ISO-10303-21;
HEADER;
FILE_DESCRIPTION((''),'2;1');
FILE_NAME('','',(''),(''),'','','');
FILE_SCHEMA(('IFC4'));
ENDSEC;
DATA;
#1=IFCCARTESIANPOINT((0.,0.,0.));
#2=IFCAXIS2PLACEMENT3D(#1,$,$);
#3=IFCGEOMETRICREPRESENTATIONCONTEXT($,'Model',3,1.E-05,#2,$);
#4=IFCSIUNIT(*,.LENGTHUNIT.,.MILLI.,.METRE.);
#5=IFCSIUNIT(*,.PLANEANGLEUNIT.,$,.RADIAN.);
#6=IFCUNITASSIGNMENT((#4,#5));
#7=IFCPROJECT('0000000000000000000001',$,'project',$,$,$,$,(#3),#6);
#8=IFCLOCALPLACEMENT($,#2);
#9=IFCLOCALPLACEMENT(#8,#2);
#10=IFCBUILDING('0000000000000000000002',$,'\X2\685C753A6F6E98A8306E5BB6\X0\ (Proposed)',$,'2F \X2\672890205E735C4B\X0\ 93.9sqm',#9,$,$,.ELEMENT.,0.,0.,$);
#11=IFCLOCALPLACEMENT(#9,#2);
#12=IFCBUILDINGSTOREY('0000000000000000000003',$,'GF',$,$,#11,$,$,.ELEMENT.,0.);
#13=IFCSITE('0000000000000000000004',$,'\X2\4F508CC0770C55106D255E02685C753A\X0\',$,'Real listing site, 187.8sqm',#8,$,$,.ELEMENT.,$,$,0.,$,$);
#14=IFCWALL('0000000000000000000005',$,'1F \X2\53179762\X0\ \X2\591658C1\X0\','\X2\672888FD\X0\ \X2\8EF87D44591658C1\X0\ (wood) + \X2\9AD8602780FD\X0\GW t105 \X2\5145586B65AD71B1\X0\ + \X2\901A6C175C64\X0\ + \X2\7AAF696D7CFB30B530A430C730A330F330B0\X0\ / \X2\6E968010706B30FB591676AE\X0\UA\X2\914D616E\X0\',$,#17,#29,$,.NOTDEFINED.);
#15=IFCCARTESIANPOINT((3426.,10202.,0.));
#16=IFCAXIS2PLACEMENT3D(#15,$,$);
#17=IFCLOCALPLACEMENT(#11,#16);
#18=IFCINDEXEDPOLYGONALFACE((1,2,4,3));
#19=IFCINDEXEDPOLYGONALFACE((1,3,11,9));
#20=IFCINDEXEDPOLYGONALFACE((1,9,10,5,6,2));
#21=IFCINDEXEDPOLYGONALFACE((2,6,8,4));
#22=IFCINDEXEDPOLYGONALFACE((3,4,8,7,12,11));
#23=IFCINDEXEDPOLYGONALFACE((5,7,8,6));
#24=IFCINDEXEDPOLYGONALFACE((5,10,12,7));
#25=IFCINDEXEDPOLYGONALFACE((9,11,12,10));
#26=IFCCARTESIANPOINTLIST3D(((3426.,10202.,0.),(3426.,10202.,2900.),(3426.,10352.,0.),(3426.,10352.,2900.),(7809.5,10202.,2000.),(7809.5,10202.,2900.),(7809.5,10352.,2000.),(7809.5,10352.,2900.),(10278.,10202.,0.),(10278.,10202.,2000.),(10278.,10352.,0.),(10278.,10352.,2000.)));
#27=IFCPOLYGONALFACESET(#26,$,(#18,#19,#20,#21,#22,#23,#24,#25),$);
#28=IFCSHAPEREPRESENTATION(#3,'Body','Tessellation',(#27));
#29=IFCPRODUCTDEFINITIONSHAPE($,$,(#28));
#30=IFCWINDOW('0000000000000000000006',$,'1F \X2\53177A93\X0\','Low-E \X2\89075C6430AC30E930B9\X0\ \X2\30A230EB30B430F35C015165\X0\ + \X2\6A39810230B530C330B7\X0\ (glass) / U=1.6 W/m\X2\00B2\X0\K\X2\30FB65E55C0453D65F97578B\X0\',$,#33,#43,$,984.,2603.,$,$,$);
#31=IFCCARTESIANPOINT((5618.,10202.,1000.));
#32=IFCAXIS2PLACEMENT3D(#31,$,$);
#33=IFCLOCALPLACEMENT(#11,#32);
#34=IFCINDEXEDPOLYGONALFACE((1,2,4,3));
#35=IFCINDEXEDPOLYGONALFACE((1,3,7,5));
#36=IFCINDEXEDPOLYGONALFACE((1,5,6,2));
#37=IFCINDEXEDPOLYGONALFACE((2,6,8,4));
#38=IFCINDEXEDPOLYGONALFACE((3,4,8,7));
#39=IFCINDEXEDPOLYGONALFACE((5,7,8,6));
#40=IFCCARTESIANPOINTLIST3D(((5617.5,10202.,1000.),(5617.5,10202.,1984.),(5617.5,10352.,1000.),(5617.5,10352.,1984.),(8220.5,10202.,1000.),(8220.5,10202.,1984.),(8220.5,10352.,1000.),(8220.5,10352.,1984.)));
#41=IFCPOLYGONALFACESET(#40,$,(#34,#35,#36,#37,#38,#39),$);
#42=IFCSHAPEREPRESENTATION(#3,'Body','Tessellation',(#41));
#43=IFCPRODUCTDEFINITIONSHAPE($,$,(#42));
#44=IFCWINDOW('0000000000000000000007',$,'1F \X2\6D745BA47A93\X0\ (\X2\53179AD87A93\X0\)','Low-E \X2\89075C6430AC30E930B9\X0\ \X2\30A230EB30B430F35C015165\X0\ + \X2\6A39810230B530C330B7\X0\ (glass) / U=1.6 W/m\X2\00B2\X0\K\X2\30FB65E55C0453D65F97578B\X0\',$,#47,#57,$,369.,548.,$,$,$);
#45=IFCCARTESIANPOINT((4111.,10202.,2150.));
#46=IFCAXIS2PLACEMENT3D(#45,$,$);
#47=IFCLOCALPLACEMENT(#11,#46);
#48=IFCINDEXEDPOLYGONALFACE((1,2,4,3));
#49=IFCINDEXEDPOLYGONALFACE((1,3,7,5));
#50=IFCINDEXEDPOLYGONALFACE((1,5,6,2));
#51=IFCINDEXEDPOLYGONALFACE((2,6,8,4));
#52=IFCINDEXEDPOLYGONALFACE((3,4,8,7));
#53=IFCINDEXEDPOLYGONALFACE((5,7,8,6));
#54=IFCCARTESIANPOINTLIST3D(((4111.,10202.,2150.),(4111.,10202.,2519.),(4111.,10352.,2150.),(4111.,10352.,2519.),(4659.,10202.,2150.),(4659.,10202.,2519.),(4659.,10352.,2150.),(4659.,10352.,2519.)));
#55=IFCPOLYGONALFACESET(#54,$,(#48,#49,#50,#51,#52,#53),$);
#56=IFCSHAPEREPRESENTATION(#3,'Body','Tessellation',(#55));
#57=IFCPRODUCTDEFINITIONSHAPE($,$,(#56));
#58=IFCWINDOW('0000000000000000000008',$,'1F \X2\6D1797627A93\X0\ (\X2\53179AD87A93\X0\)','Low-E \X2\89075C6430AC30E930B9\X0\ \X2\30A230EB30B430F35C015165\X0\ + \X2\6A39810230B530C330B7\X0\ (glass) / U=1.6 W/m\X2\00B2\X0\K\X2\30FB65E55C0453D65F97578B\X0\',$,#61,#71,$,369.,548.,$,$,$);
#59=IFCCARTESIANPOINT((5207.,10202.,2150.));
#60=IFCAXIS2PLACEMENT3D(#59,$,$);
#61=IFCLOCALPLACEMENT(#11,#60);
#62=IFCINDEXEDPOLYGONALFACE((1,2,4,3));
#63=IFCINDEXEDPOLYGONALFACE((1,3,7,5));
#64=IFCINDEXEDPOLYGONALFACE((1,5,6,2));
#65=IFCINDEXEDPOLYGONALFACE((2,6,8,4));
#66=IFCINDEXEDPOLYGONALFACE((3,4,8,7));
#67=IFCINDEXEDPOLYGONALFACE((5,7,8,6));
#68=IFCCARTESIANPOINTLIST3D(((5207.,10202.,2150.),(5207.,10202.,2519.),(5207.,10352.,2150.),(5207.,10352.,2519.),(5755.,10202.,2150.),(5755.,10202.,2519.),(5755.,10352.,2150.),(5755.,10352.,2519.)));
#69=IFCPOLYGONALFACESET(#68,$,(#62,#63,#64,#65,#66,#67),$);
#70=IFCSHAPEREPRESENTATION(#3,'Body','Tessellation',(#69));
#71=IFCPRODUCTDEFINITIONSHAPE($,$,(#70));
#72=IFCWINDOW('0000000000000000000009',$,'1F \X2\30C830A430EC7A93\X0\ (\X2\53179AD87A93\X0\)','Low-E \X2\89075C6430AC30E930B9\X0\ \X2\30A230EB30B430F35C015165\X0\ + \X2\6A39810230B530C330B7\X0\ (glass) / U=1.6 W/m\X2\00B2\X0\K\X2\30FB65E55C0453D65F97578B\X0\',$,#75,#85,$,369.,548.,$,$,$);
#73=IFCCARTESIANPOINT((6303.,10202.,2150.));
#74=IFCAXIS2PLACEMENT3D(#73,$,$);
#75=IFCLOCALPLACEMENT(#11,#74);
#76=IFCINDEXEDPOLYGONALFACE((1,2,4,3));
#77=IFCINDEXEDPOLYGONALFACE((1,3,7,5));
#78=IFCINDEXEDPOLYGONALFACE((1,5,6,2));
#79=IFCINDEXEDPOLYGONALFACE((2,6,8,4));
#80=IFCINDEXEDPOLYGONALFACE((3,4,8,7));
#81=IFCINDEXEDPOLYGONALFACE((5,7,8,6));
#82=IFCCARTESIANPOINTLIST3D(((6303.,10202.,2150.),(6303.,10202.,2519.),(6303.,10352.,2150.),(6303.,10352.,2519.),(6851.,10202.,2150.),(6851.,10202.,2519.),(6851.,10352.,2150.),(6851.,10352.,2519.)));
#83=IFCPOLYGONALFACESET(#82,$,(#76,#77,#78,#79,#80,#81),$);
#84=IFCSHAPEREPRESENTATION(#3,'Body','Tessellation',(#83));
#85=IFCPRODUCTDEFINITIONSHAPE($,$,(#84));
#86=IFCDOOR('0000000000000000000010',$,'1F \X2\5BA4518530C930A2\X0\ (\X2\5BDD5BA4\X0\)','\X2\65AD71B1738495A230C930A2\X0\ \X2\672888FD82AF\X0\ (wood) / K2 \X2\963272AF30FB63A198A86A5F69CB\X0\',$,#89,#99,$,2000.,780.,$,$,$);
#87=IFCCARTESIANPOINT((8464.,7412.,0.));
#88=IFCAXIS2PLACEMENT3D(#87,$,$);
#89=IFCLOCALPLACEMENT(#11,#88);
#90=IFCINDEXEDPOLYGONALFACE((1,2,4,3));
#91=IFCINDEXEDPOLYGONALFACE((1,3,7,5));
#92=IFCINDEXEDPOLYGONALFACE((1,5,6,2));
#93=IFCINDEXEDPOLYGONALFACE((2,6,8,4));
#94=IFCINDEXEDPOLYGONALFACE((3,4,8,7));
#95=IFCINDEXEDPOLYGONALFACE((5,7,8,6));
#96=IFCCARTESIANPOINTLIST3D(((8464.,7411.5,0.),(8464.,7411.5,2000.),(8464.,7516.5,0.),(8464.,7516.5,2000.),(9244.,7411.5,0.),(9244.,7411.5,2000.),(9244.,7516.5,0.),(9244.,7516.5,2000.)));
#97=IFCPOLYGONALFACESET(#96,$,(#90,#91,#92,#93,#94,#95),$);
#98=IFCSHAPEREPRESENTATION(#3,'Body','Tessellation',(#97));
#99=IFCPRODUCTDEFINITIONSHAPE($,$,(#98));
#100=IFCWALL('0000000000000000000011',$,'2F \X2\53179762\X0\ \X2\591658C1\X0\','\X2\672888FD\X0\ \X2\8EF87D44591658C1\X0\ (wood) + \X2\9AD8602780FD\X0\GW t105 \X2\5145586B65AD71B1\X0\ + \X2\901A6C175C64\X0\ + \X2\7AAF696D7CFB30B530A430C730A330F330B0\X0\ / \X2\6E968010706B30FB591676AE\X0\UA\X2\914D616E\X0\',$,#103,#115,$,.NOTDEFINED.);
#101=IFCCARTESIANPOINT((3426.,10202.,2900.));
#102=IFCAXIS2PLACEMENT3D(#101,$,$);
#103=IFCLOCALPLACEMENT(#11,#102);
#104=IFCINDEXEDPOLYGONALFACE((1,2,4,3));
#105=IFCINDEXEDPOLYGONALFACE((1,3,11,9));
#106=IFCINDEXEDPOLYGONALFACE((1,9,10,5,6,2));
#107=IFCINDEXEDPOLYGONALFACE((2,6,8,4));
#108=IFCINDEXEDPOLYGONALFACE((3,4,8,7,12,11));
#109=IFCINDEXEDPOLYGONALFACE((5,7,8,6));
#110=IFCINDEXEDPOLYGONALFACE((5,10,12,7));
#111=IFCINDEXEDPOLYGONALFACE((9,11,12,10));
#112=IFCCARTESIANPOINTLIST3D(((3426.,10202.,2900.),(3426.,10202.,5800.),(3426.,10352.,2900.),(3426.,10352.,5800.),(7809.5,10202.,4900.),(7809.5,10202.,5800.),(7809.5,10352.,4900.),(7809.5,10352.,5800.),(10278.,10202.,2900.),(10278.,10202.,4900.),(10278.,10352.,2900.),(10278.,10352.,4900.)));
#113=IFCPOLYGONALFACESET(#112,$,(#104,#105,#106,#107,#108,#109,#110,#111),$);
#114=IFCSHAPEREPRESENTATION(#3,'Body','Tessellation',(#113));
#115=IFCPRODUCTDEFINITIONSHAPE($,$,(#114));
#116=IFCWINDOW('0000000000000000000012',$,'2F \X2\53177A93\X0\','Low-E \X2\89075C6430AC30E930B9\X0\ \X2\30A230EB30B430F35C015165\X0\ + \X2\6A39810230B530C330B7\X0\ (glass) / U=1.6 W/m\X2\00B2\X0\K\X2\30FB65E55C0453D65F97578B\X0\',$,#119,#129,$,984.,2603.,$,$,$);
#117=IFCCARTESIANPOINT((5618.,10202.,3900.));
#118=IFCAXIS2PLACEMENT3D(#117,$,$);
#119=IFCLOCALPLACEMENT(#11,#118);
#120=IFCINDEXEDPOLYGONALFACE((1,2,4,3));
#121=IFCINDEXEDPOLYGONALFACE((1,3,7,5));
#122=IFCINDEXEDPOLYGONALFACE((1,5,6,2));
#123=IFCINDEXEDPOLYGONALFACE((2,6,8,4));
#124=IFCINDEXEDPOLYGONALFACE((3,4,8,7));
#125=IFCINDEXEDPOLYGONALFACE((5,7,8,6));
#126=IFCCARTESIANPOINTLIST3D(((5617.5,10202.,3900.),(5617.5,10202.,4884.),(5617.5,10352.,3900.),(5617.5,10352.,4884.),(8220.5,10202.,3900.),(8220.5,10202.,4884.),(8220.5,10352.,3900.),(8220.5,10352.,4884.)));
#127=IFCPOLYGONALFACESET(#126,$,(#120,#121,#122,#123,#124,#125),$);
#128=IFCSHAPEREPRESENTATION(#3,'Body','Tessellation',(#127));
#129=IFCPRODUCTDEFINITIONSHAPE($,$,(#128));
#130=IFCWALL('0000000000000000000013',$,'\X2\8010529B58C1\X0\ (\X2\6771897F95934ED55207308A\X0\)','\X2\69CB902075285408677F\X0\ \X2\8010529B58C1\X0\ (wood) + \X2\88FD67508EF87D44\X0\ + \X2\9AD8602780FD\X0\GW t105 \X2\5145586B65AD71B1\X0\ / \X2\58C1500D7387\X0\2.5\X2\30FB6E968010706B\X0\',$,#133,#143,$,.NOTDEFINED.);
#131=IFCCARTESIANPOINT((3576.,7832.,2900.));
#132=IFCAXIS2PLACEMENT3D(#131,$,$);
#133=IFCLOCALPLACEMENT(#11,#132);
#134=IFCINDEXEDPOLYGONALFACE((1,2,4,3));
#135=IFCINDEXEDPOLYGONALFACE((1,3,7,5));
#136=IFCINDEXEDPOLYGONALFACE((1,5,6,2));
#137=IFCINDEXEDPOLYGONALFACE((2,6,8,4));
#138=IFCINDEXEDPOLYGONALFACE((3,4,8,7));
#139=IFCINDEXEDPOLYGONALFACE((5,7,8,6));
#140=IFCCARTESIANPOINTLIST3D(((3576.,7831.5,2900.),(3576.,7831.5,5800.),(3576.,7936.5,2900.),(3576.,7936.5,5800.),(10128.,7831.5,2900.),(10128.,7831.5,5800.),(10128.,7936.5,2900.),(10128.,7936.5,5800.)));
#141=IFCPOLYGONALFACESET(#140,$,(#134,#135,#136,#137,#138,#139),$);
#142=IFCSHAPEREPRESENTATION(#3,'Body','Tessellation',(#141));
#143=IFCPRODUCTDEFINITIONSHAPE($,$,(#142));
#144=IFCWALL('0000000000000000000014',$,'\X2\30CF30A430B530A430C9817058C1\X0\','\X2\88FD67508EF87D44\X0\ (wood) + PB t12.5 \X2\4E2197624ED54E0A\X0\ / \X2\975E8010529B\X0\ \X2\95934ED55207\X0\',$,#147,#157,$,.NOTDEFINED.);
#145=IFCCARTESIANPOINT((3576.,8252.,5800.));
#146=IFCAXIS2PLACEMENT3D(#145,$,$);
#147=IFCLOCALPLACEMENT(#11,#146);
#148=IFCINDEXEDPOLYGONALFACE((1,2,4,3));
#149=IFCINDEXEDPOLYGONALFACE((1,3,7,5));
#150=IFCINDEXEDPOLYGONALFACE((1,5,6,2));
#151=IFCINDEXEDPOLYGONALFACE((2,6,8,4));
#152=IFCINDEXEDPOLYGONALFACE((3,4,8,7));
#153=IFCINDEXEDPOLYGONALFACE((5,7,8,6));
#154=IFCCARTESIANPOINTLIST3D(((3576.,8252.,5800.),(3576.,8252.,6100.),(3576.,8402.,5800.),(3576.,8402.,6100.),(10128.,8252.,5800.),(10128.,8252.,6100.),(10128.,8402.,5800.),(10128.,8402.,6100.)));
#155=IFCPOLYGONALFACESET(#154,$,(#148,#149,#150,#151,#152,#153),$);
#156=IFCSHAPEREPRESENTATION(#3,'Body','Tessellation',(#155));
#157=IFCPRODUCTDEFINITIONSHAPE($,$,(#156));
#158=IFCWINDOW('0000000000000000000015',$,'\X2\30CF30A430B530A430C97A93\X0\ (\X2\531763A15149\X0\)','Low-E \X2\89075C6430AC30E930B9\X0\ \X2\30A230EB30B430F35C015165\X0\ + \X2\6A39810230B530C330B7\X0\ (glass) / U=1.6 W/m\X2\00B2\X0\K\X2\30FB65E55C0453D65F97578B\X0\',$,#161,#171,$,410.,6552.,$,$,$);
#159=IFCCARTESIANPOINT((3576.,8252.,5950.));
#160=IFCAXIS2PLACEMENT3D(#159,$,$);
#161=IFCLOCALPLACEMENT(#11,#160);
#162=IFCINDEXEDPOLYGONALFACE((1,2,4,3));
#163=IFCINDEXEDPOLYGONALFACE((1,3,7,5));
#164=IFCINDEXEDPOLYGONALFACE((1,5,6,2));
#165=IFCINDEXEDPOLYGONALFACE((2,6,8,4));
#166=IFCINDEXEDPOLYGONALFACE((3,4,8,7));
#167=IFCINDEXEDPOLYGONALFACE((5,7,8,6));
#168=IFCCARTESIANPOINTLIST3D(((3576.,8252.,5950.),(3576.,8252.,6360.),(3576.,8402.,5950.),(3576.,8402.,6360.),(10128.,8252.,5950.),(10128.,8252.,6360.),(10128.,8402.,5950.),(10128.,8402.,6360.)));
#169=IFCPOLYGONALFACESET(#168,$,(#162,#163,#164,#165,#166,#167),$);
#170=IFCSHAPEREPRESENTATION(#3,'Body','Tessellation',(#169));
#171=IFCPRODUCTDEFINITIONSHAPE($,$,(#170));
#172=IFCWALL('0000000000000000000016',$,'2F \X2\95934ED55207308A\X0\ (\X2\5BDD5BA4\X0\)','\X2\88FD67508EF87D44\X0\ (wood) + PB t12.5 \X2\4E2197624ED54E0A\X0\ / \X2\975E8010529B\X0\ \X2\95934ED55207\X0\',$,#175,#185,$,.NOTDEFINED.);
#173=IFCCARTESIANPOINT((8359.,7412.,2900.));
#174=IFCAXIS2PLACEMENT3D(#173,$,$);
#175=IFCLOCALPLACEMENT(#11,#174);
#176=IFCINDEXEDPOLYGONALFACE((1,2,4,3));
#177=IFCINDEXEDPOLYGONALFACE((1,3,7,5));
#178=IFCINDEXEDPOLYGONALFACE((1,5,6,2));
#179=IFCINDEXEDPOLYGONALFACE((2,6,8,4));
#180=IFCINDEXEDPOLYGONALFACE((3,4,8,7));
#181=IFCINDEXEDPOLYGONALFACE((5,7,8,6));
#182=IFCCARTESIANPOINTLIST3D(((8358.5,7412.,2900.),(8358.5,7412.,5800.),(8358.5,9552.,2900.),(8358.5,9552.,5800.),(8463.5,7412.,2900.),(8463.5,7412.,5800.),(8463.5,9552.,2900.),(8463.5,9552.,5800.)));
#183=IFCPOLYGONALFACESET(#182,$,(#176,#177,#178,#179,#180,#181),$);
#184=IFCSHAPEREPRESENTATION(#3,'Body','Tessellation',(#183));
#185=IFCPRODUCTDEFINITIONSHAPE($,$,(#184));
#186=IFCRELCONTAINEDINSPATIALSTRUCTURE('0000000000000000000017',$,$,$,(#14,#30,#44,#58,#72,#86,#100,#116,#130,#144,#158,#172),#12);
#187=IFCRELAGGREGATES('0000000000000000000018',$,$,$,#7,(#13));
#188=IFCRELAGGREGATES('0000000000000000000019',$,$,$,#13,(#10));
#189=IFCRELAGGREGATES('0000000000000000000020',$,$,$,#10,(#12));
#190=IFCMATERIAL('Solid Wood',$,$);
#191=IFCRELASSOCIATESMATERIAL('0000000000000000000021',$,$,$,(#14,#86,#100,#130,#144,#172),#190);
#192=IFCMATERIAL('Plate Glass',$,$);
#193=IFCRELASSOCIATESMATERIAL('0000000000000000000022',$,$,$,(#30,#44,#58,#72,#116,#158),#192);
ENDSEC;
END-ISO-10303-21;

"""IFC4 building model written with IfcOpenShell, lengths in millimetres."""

from ifc_helpers import new_model, si_unit, frame, frame_2d, origin, place, context, project, spatial, rectangle, extrude, material, element, fill, save


model = new_model("IFC4")

# Units and contexts
model_context = context("Model", 3, precision=1e-05, world=origin())
ifc_project = project(units=[si_unit("LENGTHUNIT", "METRE", prefix="MILLI"), si_unit("PLANEANGLEUNIT", "RADIAN")], contexts=[model_context])

# Site, building, storey
site_placement = place(None, origin())
site = spatial("IfcSite", under=ifc_project, at=site_placement, Name="佐賀県唐津市桜町", ObjectType="Real listing site, 187.8sqm", CompositionType="ELEMENT", RefElevation=0.0)
building_placement = place(site_placement, origin())
building = spatial("IfcBuilding", under=site, at=building_placement, Name="桜町潮風の家 (Proposed)", ObjectType="2F 木造平屋 93.9sqm", CompositionType="ELEMENT", ElevationOfRefHeight=0.0, ElevationOfTerrain=0.0)
storey_placement = place(building_placement, origin())
storey = spatial("IfcBuildingStorey", under=building, at=storey_placement, Name="GF", CompositionType="ELEMENT", Elevation=0.0)

# Wall, openings, windows
ifc_material_1 = material(Name="Solid Wood")
wall_1_placement = place(storey_placement, frame((3426.0, 10202.0, 0.0)))
wall_1 = element("IfcWall", 1, at=wall_1_placement, inside=storey, material=ifc_material_1, Name="1F 北面 外壁", Description="木製 軸組外壁 (wood) + 高性能GW t105 充填断熱 + 通気層 + 窯業系サイディング / 準耐火・外皮UA配慮", PredefinedType="NOTDEFINED", context=model_context, shape_type="SweptSolid", body=[
    extrude(rectangle(XDim=6852.0, YDim=150.0, at=frame_2d((3426.0, 75.0))), frame((3426.0, 10202.0, 0.0)), (0.0, 0.0, 1.0), 2900.0),
])
opening_1_placement = place(storey_placement, frame((5618.0, 10202.0, 1000.0)))
opening_1 = element("IfcOpeningElement", 2, at=opening_1_placement, cuts=wall_1, PredefinedType="NOTDEFINED", context=model_context, shape_type="SweptSolid", body=[
    extrude(rectangle(XDim=2603.0, YDim=150.0, at=frame_2d((1301.0, 75.0))), frame((5618.0, 10202.0, 1000.0)), (0.0, 0.0, 1.0), 984.0),
])
opening_2_placement = place(storey_placement, frame((4111.0, 10202.0, 2150.0)))
opening_2 = element("IfcOpeningElement", 3, at=opening_2_placement, cuts=wall_1, PredefinedType="NOTDEFINED", context=model_context, shape_type="SweptSolid", body=[
    extrude(rectangle(XDim=548.0, YDim=150.0, at=frame_2d((274.0, 75.0))), frame((4111.0, 10202.0, 2150.0)), (0.0, 0.0, 1.0), 369.0),
])
opening_3_placement = place(storey_placement, frame((5207.0, 10202.0, 2150.0)))
opening_3 = element("IfcOpeningElement", 4, at=opening_3_placement, cuts=wall_1, PredefinedType="NOTDEFINED", context=model_context, shape_type="SweptSolid", body=[
    extrude(rectangle(XDim=548.0, YDim=150.0, at=frame_2d((274.0, 75.0))), frame((5207.0, 10202.0, 2150.0)), (0.0, 0.0, 1.0), 369.0),
])
opening_4_placement = place(storey_placement, frame((6303.0, 10202.0, 2150.0)))
opening_4 = element("IfcOpeningElement", 5, at=opening_4_placement, cuts=wall_1, PredefinedType="NOTDEFINED", context=model_context, shape_type="SweptSolid", body=[
    extrude(rectangle(XDim=548.0, YDim=150.0, at=frame_2d((274.0, 75.0))), frame((6303.0, 10202.0, 2150.0)), (0.0, 0.0, 1.0), 369.0),
])
ifc_material_2 = material(Name="Plate Glass")
window_1_placement = place(storey_placement, frame((5618.0, 10202.0, 1000.0)))
window_1 = element("IfcWindow", 6, at=window_1_placement, inside=storey, material=ifc_material_2, Name="1F 北窓", Description="Low-E 複層ガラス アルゴン封入 + 樹脂サッシ (glass) / U=1.6 W/m²K・日射取得型", OverallHeight=984.0, OverallWidth=2603.0, context=model_context, shape_type="SweptSolid", body=[
    extrude(rectangle(XDim=2603.0, YDim=150.0, at=frame_2d((1301.0, 75.0))), frame((5618.0, 10202.0, 1000.0)), (0.0, 0.0, 1.0), 984.0),
])
fill(opening_1, window_1)
window_2_placement = place(storey_placement, frame((4111.0, 10202.0, 2150.0)))
window_2 = element("IfcWindow", 7, at=window_2_placement, inside=storey, material=ifc_material_2, Name="1F 浴室窓 (北高窓)", Description="Low-E 複層ガラス アルゴン封入 + 樹脂サッシ (glass) / U=1.6 W/m²K・日射取得型", OverallHeight=369.0, OverallWidth=548.0, context=model_context, shape_type="SweptSolid", body=[
    extrude(rectangle(XDim=548.0, YDim=150.0, at=frame_2d((274.0, 75.0))), frame((4111.0, 10202.0, 2150.0)), (0.0, 0.0, 1.0), 369.0),
])
fill(opening_2, window_2)
window_3_placement = place(storey_placement, frame((5207.0, 10202.0, 2150.0)))
window_3 = element("IfcWindow", 8, at=window_3_placement, inside=storey, material=ifc_material_2, Name="1F 洗面窓 (北高窓)", Description="Low-E 複層ガラス アルゴン封入 + 樹脂サッシ (glass) / U=1.6 W/m²K・日射取得型", OverallHeight=369.0, OverallWidth=548.0, context=model_context, shape_type="SweptSolid", body=[
    extrude(rectangle(XDim=548.0, YDim=150.0, at=frame_2d((274.0, 75.0))), frame((5207.0, 10202.0, 2150.0)), (0.0, 0.0, 1.0), 369.0),
])
fill(opening_3, window_3)
window_4_placement = place(storey_placement, frame((6303.0, 10202.0, 2150.0)))
window_4 = element("IfcWindow", 9, at=window_4_placement, inside=storey, material=ifc_material_2, Name="1F トイレ窓 (北高窓)", Description="Low-E 複層ガラス アルゴン封入 + 樹脂サッシ (glass) / U=1.6 W/m²K・日射取得型", OverallHeight=369.0, OverallWidth=548.0, context=model_context, shape_type="SweptSolid", body=[
    extrude(rectangle(XDim=548.0, YDim=150.0, at=frame_2d((274.0, 75.0))), frame((6303.0, 10202.0, 2150.0)), (0.0, 0.0, 1.0), 369.0),
])
fill(opening_4, window_4)

# Door
door_1_placement = place(storey_placement, frame((8464.0, 7412.0, 0.0)))
element("IfcDoor", 10, at=door_1_placement, inside=storey, material=ifc_material_1, Name="1F 室内ドア (寝室)", Description="断熱玄関ドア 木製芯 (wood) / K2 防犯・採風機構", OverallHeight=2000.0, OverallWidth=780.0, context=model_context, shape_type="SweptSolid", body=[
    extrude(rectangle(XDim=780.0, YDim=105.0, at=frame_2d((390.0, 52.0))), frame((8464.0, 7412.0, 0.0)), (0.0, 0.0, 1.0), 2000.0),
])

# Wall, opening, window
wall_2_placement = place(storey_placement, frame((3426.0, 10202.0, 2900.0)))
wall_2 = element("IfcWall", 11, at=wall_2_placement, inside=storey, material=ifc_material_1, Name="2F 北面 外壁", Description="木製 軸組外壁 (wood) + 高性能GW t105 充填断熱 + 通気層 + 窯業系サイディング / 準耐火・外皮UA配慮", PredefinedType="NOTDEFINED", context=model_context, shape_type="SweptSolid", body=[
    extrude(rectangle(XDim=6852.0, YDim=150.0, at=frame_2d((3426.0, 75.0))), frame((3426.0, 10202.0, 2900.0)), (0.0, 0.0, 1.0), 2900.0),
])
opening_5_placement = place(storey_placement, frame((5618.0, 10202.0, 3900.0)))
opening_5 = element("IfcOpeningElement", 12, at=opening_5_placement, cuts=wall_2, PredefinedType="NOTDEFINED", context=model_context, shape_type="SweptSolid", body=[
    extrude(rectangle(XDim=2603.0, YDim=150.0, at=frame_2d((1301.0, 75.0))), frame((5618.0, 10202.0, 3900.0)), (0.0, 0.0, 1.0), 984.0),
])
window_5_placement = place(storey_placement, frame((5618.0, 10202.0, 3900.0)))
window_5 = element("IfcWindow", 13, at=window_5_placement, inside=storey, material=ifc_material_2, Name="2F 北窓", Description="Low-E 複層ガラス アルゴン封入 + 樹脂サッシ (glass) / U=1.6 W/m²K・日射取得型", OverallHeight=984.0, OverallWidth=2603.0, context=model_context, shape_type="SweptSolid", body=[
    extrude(rectangle(XDim=2603.0, YDim=150.0, at=frame_2d((1301.0, 75.0))), frame((5618.0, 10202.0, 3900.0)), (0.0, 0.0, 1.0), 984.0),
])
fill(opening_5, window_5)

# Wall
wall_3_placement = place(storey_placement, frame((3576.0, 7832.0, 2900.0)))
element("IfcWall", 14, at=wall_3_placement, inside=storey, material=ifc_material_1, Name="耐力壁 (東西間仕切り)", Description="構造用合板 耐力壁 (wood) + 製材軸組 + 高性能GW t105 充填断熱 / 壁倍率2.5・準耐火", PredefinedType="NOTDEFINED", context=model_context, shape_type="SweptSolid", body=[
    extrude(rectangle(XDim=6552.0, YDim=105.0, at=frame_2d((3276.0, 52.0))), frame((3576.0, 7832.0, 2900.0)), (0.0, 0.0, 1.0), 2900.0),
])

# Wall, opening, window
wall_4_placement = place(storey_placement, frame((3576.0, 8252.0, 5800.0)))
wall_4 = element("IfcWall", 15, at=wall_4_placement, inside=storey, material=ifc_material_1, Name="ハイサイド腰壁", Description="製材軸組 (wood) + PB t12.5 両面仕上 / 非耐力 間仕切", PredefinedType="NOTDEFINED", context=model_context, shape_type="SweptSolid", body=[
    extrude(rectangle(XDim=6552.0, YDim=150.0, at=frame_2d((3276.0, 75.0))), frame((3576.0, 8252.0, 5800.0)), (0.0, 0.0, 1.0), 700.0),
])
opening_6_placement = place(storey_placement, frame((3576.0, 8252.0, 5950.0)))
opening_6 = element("IfcOpeningElement", 16, at=opening_6_placement, cuts=wall_4, PredefinedType="NOTDEFINED", context=model_context, shape_type="SweptSolid", body=[
    extrude(rectangle(XDim=6552.0, YDim=150.0, at=frame_2d((3276.0, 75.0))), frame((3576.0, 8252.0, 5950.0)), (0.0, 0.0, 1.0), 410.0),
])
window_6_placement = place(storey_placement, frame((3576.0, 8252.0, 5950.0)))
window_6 = element("IfcWindow", 17, at=window_6_placement, inside=storey, material=ifc_material_2, Name="ハイサイド窓 (北採光)", Description="Low-E 複層ガラス アルゴン封入 + 樹脂サッシ (glass) / U=1.6 W/m²K・日射取得型", OverallHeight=410.0, OverallWidth=6552.0, context=model_context, shape_type="SweptSolid", body=[
    extrude(rectangle(XDim=6552.0, YDim=150.0, at=frame_2d((3276.0, 75.0))), frame((3576.0, 8252.0, 5950.0)), (0.0, 0.0, 1.0), 410.0),
])
fill(opening_6, window_6)

# Wall
wall_5_placement = place(storey_placement, frame((8359.0, 7412.0, 2900.0)))
element("IfcWall", 18, at=wall_5_placement, inside=storey, material=ifc_material_1, Name="2F 間仕切り (寝室)", Description="製材軸組 (wood) + PB t12.5 両面仕上 / 非耐力 間仕切", PredefinedType="NOTDEFINED", context=model_context, shape_type="SweptSolid", body=[
    extrude(rectangle(XDim=105.0, YDim=2140.0, at=frame_2d((52.0, 1070.0))), frame((8359.0, 7412.0, 2900.0)), (0.0, 0.0, 1.0), 2900.0),
])

save(model, "model.ifc")
